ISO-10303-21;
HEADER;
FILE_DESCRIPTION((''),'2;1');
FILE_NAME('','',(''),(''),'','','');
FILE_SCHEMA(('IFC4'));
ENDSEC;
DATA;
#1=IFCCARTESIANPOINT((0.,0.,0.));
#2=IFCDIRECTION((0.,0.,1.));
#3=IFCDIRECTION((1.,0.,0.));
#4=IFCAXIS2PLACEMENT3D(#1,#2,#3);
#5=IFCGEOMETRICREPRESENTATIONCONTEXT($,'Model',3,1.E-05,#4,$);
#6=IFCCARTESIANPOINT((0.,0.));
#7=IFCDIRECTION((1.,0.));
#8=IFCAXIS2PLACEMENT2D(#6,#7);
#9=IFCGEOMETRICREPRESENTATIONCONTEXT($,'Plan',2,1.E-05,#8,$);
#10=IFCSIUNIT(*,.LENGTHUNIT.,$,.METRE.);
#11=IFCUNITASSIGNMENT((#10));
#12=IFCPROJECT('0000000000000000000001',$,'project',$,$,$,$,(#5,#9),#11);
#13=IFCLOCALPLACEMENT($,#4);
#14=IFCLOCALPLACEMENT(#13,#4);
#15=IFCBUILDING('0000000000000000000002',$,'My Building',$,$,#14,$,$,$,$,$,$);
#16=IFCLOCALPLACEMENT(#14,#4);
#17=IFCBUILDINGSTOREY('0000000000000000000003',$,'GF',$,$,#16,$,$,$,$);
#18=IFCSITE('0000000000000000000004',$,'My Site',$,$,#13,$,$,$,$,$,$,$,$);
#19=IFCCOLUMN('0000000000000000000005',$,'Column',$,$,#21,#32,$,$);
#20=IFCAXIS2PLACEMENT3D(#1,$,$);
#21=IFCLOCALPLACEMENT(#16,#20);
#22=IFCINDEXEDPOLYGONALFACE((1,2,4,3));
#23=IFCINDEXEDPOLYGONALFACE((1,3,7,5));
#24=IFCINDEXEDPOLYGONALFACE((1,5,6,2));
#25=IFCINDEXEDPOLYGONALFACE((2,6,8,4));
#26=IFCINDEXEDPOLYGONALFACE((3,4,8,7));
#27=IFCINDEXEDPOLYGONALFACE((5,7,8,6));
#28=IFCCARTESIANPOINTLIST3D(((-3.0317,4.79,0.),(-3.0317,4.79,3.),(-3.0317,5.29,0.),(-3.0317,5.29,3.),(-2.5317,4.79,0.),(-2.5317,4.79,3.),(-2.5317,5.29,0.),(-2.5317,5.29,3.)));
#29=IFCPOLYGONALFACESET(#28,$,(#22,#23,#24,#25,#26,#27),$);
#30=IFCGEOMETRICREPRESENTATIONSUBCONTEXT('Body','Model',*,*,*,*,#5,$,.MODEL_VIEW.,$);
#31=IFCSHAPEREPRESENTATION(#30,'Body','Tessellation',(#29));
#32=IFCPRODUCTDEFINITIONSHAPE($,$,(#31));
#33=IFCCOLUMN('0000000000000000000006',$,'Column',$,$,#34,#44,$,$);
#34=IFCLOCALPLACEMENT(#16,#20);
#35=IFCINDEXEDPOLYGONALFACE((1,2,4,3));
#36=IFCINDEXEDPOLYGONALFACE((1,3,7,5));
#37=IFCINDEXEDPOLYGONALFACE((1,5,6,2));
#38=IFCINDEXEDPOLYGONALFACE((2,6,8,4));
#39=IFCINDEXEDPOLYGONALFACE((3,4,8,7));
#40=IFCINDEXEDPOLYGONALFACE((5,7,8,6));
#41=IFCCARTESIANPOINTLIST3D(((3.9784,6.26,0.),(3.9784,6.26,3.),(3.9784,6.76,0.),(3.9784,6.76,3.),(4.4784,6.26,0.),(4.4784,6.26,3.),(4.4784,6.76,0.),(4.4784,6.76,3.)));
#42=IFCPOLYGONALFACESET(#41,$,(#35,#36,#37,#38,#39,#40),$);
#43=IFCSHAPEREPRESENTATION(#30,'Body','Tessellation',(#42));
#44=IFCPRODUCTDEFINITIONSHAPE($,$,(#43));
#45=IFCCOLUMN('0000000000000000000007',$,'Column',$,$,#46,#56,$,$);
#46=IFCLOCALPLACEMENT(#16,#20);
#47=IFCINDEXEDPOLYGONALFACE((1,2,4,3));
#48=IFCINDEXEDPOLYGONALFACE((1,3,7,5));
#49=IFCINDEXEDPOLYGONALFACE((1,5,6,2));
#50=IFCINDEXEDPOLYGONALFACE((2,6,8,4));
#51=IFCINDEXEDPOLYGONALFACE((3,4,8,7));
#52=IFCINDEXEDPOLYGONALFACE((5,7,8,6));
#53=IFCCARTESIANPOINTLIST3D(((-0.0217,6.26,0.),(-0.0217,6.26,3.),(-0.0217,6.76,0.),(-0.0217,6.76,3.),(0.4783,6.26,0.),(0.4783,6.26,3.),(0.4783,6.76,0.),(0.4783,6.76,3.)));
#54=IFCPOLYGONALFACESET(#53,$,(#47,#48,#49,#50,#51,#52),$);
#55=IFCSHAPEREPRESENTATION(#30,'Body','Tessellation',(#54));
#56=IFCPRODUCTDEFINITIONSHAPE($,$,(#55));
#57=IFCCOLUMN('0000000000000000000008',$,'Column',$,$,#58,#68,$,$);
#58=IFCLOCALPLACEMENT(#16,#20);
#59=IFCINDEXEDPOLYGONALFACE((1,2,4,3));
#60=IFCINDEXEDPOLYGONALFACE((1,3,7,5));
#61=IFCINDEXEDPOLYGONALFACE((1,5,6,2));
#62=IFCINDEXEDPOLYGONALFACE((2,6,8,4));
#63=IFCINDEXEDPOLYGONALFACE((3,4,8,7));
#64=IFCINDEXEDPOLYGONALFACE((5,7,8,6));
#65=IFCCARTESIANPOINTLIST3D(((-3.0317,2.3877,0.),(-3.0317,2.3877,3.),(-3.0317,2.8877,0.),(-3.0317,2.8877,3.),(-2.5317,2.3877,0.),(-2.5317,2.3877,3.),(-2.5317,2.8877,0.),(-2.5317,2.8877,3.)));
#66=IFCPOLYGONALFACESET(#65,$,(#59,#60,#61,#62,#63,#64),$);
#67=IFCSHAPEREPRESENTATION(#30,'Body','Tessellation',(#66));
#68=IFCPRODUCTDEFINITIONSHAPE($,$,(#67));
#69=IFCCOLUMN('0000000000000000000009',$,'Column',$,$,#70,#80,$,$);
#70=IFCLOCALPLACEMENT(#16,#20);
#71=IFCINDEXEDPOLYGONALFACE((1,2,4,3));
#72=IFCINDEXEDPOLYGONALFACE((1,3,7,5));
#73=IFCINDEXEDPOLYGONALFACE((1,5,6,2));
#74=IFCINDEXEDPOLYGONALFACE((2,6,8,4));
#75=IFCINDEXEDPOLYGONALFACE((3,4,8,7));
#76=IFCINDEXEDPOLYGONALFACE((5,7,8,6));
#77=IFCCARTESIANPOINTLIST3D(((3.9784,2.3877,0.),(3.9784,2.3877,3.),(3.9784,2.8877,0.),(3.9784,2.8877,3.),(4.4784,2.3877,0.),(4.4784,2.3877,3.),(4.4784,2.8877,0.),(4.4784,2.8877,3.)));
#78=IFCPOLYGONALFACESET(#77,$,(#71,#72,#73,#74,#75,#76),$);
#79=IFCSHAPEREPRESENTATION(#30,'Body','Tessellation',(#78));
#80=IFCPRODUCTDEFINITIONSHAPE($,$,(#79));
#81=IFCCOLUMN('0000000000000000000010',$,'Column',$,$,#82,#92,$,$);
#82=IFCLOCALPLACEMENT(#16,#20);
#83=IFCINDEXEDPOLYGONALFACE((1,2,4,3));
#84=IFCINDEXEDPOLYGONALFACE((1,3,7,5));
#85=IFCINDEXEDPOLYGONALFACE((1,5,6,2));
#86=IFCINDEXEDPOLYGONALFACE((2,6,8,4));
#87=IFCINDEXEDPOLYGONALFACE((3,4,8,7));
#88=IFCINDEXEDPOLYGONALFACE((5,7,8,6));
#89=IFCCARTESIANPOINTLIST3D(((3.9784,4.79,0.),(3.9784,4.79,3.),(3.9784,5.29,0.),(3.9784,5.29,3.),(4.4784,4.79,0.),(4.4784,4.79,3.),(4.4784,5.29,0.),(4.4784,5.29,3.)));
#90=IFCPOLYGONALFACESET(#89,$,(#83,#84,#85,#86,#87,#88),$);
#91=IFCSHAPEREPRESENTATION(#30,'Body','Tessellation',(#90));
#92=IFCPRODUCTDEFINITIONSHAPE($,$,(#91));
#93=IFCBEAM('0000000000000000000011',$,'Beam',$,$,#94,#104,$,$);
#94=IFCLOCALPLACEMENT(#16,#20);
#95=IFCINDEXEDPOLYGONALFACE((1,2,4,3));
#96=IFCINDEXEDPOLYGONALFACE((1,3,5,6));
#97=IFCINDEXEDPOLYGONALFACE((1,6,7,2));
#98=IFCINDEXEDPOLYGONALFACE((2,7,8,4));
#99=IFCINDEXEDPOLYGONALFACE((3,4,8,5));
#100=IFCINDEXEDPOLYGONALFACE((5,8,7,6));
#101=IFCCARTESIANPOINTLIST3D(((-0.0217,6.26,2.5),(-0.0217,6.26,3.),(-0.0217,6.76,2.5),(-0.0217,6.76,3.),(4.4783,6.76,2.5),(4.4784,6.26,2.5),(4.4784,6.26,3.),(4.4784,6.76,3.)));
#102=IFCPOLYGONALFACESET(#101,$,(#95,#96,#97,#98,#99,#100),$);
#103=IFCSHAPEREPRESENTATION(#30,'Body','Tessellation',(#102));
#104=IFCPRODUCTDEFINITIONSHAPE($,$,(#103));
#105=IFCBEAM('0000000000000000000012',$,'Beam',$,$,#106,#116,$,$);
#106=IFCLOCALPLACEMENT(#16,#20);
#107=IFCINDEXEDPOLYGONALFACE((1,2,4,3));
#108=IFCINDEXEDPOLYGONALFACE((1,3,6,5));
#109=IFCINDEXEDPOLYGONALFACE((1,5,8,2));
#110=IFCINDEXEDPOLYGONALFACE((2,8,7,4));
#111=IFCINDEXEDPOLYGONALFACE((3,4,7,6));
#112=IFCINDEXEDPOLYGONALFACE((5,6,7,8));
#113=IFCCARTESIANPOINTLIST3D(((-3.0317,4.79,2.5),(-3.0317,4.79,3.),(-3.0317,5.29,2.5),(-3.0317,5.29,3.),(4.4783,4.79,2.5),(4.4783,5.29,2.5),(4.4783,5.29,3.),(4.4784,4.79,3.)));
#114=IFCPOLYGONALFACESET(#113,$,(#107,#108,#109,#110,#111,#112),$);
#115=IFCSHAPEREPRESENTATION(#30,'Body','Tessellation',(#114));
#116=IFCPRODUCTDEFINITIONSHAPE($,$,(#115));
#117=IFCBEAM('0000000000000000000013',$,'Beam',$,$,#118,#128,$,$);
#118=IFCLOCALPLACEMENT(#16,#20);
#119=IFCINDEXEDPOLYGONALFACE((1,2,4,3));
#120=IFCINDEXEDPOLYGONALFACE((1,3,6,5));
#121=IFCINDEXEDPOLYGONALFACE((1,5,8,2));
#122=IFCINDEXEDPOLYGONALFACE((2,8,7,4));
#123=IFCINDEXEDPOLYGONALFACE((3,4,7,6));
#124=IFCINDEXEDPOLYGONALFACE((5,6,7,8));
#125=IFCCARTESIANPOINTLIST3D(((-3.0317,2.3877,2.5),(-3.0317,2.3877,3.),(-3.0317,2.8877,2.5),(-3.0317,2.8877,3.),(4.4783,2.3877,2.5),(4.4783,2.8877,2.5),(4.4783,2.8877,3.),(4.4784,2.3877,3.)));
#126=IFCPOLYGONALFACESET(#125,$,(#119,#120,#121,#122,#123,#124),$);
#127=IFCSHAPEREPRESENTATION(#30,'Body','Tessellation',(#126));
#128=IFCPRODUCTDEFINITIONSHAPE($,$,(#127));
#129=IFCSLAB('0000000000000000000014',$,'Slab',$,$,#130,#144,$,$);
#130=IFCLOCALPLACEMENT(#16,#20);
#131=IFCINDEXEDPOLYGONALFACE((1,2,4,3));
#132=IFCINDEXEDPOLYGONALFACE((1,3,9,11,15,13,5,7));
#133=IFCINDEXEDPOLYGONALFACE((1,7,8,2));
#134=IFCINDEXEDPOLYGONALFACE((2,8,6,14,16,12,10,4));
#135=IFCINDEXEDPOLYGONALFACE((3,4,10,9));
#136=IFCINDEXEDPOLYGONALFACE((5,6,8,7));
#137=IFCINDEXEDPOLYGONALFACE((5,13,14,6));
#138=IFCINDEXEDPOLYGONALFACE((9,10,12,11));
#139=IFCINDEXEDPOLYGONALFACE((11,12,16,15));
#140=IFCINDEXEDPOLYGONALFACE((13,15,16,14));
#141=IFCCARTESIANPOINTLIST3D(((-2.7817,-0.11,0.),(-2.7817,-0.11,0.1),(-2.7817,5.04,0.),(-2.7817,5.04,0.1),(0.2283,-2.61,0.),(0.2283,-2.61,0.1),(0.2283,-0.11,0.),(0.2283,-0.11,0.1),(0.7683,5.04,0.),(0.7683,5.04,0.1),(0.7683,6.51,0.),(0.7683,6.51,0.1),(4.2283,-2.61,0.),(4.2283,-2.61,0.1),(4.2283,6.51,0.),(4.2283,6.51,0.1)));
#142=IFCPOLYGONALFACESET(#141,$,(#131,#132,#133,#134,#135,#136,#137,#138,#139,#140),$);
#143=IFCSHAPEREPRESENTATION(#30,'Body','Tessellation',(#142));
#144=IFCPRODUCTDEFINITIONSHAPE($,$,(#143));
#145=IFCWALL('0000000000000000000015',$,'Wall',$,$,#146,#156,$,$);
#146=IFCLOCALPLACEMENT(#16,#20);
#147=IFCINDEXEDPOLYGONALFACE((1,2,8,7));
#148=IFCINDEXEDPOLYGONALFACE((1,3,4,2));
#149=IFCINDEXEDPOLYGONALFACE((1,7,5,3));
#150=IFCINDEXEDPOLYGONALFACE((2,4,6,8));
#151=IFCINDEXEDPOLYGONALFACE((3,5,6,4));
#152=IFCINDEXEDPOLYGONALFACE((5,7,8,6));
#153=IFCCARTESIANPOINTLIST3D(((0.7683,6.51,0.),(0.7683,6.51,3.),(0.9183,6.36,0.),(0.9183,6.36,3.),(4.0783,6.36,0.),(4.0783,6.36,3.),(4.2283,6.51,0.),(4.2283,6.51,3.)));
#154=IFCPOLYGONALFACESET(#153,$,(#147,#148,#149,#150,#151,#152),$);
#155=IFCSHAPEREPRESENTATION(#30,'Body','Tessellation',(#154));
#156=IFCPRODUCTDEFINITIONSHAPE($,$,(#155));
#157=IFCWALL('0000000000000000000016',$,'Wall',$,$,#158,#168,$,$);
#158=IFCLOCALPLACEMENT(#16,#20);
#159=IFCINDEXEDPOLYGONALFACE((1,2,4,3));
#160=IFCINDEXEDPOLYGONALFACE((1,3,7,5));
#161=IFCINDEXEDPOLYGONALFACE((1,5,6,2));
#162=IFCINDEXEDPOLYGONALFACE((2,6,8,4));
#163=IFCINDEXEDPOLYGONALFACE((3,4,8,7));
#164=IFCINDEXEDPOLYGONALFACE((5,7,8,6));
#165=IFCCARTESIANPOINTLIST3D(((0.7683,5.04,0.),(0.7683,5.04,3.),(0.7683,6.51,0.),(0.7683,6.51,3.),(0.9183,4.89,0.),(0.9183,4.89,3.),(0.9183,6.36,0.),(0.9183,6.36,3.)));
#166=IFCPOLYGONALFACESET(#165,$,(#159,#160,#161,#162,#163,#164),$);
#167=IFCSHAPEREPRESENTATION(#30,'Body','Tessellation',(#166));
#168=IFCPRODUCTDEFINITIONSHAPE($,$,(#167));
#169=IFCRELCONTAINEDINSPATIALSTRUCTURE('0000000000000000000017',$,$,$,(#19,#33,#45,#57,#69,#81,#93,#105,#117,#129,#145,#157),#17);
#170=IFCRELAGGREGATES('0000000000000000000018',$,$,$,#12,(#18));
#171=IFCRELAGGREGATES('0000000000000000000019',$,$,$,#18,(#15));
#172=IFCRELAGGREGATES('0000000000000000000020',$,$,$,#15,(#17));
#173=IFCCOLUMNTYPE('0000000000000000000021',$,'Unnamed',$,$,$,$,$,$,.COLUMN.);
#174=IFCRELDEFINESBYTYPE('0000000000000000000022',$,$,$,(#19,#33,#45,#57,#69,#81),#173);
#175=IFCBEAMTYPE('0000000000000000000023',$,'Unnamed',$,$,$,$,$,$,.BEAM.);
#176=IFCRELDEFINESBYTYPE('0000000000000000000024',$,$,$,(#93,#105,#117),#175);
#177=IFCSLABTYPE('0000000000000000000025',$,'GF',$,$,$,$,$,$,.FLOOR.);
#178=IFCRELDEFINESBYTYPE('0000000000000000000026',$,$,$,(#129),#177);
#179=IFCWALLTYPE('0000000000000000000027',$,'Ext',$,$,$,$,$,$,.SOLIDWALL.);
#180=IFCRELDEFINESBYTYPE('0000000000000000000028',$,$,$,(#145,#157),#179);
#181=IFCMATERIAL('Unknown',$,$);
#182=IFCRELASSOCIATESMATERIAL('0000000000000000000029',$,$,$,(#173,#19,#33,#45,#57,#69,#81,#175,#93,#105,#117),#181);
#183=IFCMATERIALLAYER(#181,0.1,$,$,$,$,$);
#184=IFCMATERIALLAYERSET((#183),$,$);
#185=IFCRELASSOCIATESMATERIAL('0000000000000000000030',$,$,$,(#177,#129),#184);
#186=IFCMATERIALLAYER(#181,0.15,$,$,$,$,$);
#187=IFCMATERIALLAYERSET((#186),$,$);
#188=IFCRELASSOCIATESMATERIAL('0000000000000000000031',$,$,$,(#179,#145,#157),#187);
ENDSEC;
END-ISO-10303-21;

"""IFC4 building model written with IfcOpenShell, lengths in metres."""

from ifc_helpers import new_model, si_unit, frame, origin_with_axes, origin_2d_with_axis, place, context, subcontext, project, spatial, line, indexed_curve, outline, extrude, material, layer, layer_set, layer_usage, material_profile, profile_set, profile_usage, type_object, element, save


model = new_model("IFC4")

# Units and contexts
model_context = context("Model", 3, precision=1e-05, world=origin_with_axes())
plan_context = context("Plan", 2, precision=1e-05, world=origin_2d_with_axis())
body_context_1 = subcontext(model_context, "Body", "Model", "MODEL_VIEW")
ifc_project = project(units=[si_unit("LENGTHUNIT", "METRE")], contexts=[model_context, plan_context])

# Site, building, storey
site_placement = place(None, origin_with_axes())
site = spatial("IfcSite", under=ifc_project, at=site_placement, Name="My Site")
building_placement = place(site_placement, origin_with_axes())
building = spatial("IfcBuilding", under=site, at=building_placement, Name="My Building")
storey_placement = place(building_placement, origin_with_axes())
storey = spatial("IfcBuildingStorey", under=building, at=storey_placement, Name="GF")

# Columns
ifc_material = material(Name="Unknown")
ifc_material_profile_1 = material_profile(ifc_material, outline(indexed_curve([(-0.25, -0.25), (0.25, -0.25), (0.25, 0.25), (-0.25, 0.25), (-0.25, -0.25)])))
ifc_profile_set_1 = profile_set([ifc_material_profile_1])
ifc_profile_usage_1 = profile_usage(ifc_profile_set_1, cardinal=5)
column_type = type_object("IfcColumnType", Name="Unnamed", PredefinedType="COLUMN", material=ifc_profile_set_1)
column_1_placement = place(storey_placement, frame((-2.7817, 5.04, 0.0), z_axis=(0.0, 0.0, 1.0), x_axis=(1.0, 0.0, 0.0)))
element("IfcColumn", 1, at=column_1_placement, inside=storey, type_object=column_type, material=ifc_profile_usage_1, Name="Column", context=body_context_1, shape_type="SweptSolid", body=[
    extrude(outline(indexed_curve([(-0.25, -0.25), (0.25, -0.25), (0.25, 0.25), (-0.25, 0.25), (-0.25, -0.25)])), origin_with_axes(), (0.0, 0.0, 1.0), 3.0),
])
ifc_profile_usage_2 = profile_usage(ifc_profile_set_1, cardinal=5)
column_2_placement = place(storey_placement, frame((4.2284, 6.51, 0.0), z_axis=(0.0, 0.0, 1.0), x_axis=(1.0, 0.0, 0.0)))
element("IfcColumn", 2, at=column_2_placement, inside=storey, type_object=column_type, material=ifc_profile_usage_2, Name="Column", context=body_context_1, shape_type="SweptSolid", body=[
    extrude(outline(indexed_curve([(-0.25, -0.25), (0.25, -0.25), (0.25, 0.25), (-0.25, 0.25), (-0.25, -0.25)])), origin_with_axes(), (0.0, 0.0, 1.0), 3.0),
])
ifc_profile_usage_3 = profile_usage(ifc_profile_set_1, cardinal=5)
column_3_placement = place(storey_placement, frame((0.2283, 6.51, 0.0), z_axis=(0.0, 0.0, 1.0), x_axis=(1.0, 0.0, 0.0)))
element("IfcColumn", 3, at=column_3_placement, inside=storey, type_object=column_type, material=ifc_profile_usage_3, Name="Column", context=body_context_1, shape_type="SweptSolid", body=[
    extrude(outline(indexed_curve([(-0.25, -0.25), (0.25, -0.25), (0.25, 0.25), (-0.25, 0.25), (-0.25, -0.25)])), origin_with_axes(), (0.0, 0.0, 1.0), 3.0),
])
ifc_profile_usage_4 = profile_usage(ifc_profile_set_1, cardinal=5)
column_4_placement = place(storey_placement, frame((-2.7817, 2.6377, 0.0), z_axis=(0.0, 0.0, 1.0), x_axis=(1.0, 0.0, 0.0)))
element("IfcColumn", 4, at=column_4_placement, inside=storey, type_object=column_type, material=ifc_profile_usage_4, Name="Column", context=body_context_1, shape_type="SweptSolid", body=[
    extrude(outline(indexed_curve([(-0.25, -0.25), (0.25, -0.25), (0.25, 0.25), (-0.25, 0.25), (-0.25, -0.25)])), origin_with_axes(), (0.0, 0.0, 1.0), 3.0),
])
ifc_profile_usage_5 = profile_usage(ifc_profile_set_1, cardinal=5)
column_5_placement = place(storey_placement, frame((4.2284, 2.6377, 0.0), z_axis=(0.0, 0.0, 1.0), x_axis=(1.0, 0.0, 0.0)))
element("IfcColumn", 5, at=column_5_placement, inside=storey, type_object=column_type, material=ifc_profile_usage_5, Name="Column", context=body_context_1, shape_type="SweptSolid", body=[
    extrude(outline(indexed_curve([(-0.25, -0.25), (0.25, -0.25), (0.25, 0.25), (-0.25, 0.25), (-0.25, -0.25)])), origin_with_axes(), (0.0, 0.0, 1.0), 3.0),
])
ifc_profile_usage_6 = profile_usage(ifc_profile_set_1, cardinal=5)
column_6_placement = place(storey_placement, frame((4.2284, 5.04, 0.0), z_axis=(0.0, 0.0, 1.0), x_axis=(1.0, 0.0, 0.0)))
element("IfcColumn", 6, at=column_6_placement, inside=storey, type_object=column_type, material=ifc_profile_usage_6, Name="Column", context=body_context_1, shape_type="SweptSolid", body=[
    extrude(outline(indexed_curve([(-0.25, -0.25), (0.25, -0.25), (0.25, 0.25), (-0.25, 0.25), (-0.25, -0.25)])), origin_with_axes(), (0.0, 0.0, 1.0), 3.0),
])

# Beams
ifc_material_profile_2 = material_profile(ifc_material, outline(indexed_curve([(-0.25, -0.25), (0.25, -0.25), (0.25, 0.25), (-0.25, 0.25), (-0.25, -0.25)])))
ifc_profile_set_2 = profile_set([ifc_material_profile_2])
ifc_profile_usage_7 = profile_usage(ifc_profile_set_2, cardinal=7)
beam_type = type_object("IfcBeamType", Name="Unnamed", PredefinedType="BEAM", material=ifc_profile_set_2)
beam_1_placement = place(storey_placement, frame((4.4784, 6.26, 3.0), z_axis=(-1.0, 0.0, 0.0), x_axis=(0.0, -1.0, 0.0)))
element("IfcBeam", 7, at=beam_1_placement, inside=storey, type_object=beam_type, material=ifc_profile_usage_7, Name="Beam", context=body_context_1, shape_type="SweptSolid", body=[
    extrude(outline(indexed_curve([(-0.25, -0.25), (0.25, -0.25), (0.25, 0.25), (-0.25, 0.25), (-0.25, -0.25)])), frame((-0.25, -0.25, 0.0), z_axis=(0.0, 0.0, 1.0), x_axis=(1.0, 0.0, 0.0)), (0.0, 0.0, 1.0), 4.5),
])
ifc_profile_usage_8 = profile_usage(ifc_profile_set_2, cardinal=7)
beam_2_placement = place(storey_placement, frame((4.4784, 4.79, 3.0), z_axis=(-1.0, -0.000001, 0.000001), x_axis=(0.000001, -1.0, 0.0)))
element("IfcBeam", 8, at=beam_2_placement, inside=storey, type_object=beam_type, material=ifc_profile_usage_8, Name="Beam", context=body_context_1, shape_type="SweptSolid", body=[
    extrude(outline(indexed_curve([(-0.25, -0.25), (0.25, -0.25), (0.25, 0.25), (-0.25, 0.25), (-0.25, -0.25)])), frame((-0.25, -0.25, 0.0), z_axis=(0.0, 0.0, 1.0), x_axis=(1.0, 0.0, 0.0)), (0.0, 0.0, 1.0), 7.51),
])
ifc_profile_usage_9 = profile_usage(ifc_profile_set_2, cardinal=7)
beam_3_placement = place(storey_placement, frame((4.4784, 2.3877, 3.0), z_axis=(-1.0, -0.000001, 0.000001), x_axis=(0.000001, -1.0, 0.0)))
element("IfcBeam", 9, at=beam_3_placement, inside=storey, type_object=beam_type, material=ifc_profile_usage_9, Name="Beam", context=body_context_1, shape_type="SweptSolid", body=[
    extrude(outline(indexed_curve([(-0.25, -0.25), (0.25, -0.25), (0.25, 0.25), (-0.25, 0.25), (-0.25, -0.25)])), frame((-0.25, -0.25, 0.0), z_axis=(0.0, 0.0, 1.0), x_axis=(1.0, 0.0, 0.0)), (0.0, 0.0, 1.0), 7.51),
])

# Slab
ifc_layer_1 = layer(ifc_material, 0.1)
ifc_layer_set_1 = layer_set([ifc_layer_1])
ifc_layer_usage_1 = layer_usage(ifc_layer_set_1, "AXIS3", "POSITIVE", -0.1)
slab_type = type_object("IfcSlabType", Name="GF", PredefinedType="FLOOR", material=ifc_layer_set_1)
slab_placement = place(storey_placement, frame((-2.7817, 5.04, 0.1), z_axis=(0.0, 0.0, 1.0), x_axis=(1.0, 0.0, 0.0)))
element("IfcSlab", 10, at=slab_placement, inside=storey, type_object=slab_type, material=ifc_layer_usage_1, Name="Slab", context=body_context_1, shape_type="SweptSolid", body=[
    extrude(outline(indexed_curve([(0.0, 0.0), (3.55, 0.0), (3.55, 1.47), (7.01, 1.47), (7.01, -7.65), (3.01, -7.65), (3.01, -5.15), (0.0, -5.15), (0.0, 0.0)])), frame((0.0, 0.0, -0.1), z_axis=(0.0, 0.0, 1.0), x_axis=(1.0, 0.0, 0.0)), (0.0, 0.0, 1.0), 0.1),
])

# Walls
ifc_layer_2 = layer(ifc_material, 0.15)
ifc_layer_set_2 = layer_set([ifc_layer_2])
ifc_layer_usage_2 = layer_usage(ifc_layer_set_2, "AXIS2", "POSITIVE", 0.0)
wall_type_1 = type_object("IfcWallType", Name="Ext", PredefinedType="SOLIDWALL", material=ifc_layer_set_2)
wall_1_placement = place(storey_placement, frame((4.2283, 6.51, 0.0), z_axis=(0.0, 0.0, 1.0), x_axis=(-1.0, 0.0, 0.0)))
element("IfcWall", 11, at=wall_1_placement, inside=storey, type_object=wall_type_1, material=ifc_layer_usage_2, Name="Wall", context=body_context_1, shape_type="SweptSolid", body=[
    extrude(outline(indexed_curve([(0.0, 0.0), (0.15, 0.15), (3.31, 0.15), (3.46, 0.0)], segments=[line(1, 2, 3, 4, 1)])), origin_with_axes(), (0.0, 0.0, 1.0), 3.0),
])
ifc_layer_usage_3 = layer_usage(ifc_layer_set_2, "AXIS2", "POSITIVE", 0.0)
wall_2_placement = place(storey_placement, frame((0.7683, 6.51, 0.0), z_axis=(0.0, 0.0, 1.0), x_axis=(0.0, -1.0, 0.0)))
element("IfcWall", 12, at=wall_2_placement, inside=storey, type_object=wall_type_1, material=ifc_layer_usage_3, Name="Wall", context=body_context_1, shape_type="SweptSolid", body=[
    extrude(outline(indexed_curve([(0.0, 0.0), (0.15, 0.15), (1.62, 0.15), (1.47, 0.0)], segments=[line(1, 2, 3, 4, 1)])), origin_with_axes(), (0.0, 0.0, 1.0), 3.0),
])

save(model, "model.ifc")
